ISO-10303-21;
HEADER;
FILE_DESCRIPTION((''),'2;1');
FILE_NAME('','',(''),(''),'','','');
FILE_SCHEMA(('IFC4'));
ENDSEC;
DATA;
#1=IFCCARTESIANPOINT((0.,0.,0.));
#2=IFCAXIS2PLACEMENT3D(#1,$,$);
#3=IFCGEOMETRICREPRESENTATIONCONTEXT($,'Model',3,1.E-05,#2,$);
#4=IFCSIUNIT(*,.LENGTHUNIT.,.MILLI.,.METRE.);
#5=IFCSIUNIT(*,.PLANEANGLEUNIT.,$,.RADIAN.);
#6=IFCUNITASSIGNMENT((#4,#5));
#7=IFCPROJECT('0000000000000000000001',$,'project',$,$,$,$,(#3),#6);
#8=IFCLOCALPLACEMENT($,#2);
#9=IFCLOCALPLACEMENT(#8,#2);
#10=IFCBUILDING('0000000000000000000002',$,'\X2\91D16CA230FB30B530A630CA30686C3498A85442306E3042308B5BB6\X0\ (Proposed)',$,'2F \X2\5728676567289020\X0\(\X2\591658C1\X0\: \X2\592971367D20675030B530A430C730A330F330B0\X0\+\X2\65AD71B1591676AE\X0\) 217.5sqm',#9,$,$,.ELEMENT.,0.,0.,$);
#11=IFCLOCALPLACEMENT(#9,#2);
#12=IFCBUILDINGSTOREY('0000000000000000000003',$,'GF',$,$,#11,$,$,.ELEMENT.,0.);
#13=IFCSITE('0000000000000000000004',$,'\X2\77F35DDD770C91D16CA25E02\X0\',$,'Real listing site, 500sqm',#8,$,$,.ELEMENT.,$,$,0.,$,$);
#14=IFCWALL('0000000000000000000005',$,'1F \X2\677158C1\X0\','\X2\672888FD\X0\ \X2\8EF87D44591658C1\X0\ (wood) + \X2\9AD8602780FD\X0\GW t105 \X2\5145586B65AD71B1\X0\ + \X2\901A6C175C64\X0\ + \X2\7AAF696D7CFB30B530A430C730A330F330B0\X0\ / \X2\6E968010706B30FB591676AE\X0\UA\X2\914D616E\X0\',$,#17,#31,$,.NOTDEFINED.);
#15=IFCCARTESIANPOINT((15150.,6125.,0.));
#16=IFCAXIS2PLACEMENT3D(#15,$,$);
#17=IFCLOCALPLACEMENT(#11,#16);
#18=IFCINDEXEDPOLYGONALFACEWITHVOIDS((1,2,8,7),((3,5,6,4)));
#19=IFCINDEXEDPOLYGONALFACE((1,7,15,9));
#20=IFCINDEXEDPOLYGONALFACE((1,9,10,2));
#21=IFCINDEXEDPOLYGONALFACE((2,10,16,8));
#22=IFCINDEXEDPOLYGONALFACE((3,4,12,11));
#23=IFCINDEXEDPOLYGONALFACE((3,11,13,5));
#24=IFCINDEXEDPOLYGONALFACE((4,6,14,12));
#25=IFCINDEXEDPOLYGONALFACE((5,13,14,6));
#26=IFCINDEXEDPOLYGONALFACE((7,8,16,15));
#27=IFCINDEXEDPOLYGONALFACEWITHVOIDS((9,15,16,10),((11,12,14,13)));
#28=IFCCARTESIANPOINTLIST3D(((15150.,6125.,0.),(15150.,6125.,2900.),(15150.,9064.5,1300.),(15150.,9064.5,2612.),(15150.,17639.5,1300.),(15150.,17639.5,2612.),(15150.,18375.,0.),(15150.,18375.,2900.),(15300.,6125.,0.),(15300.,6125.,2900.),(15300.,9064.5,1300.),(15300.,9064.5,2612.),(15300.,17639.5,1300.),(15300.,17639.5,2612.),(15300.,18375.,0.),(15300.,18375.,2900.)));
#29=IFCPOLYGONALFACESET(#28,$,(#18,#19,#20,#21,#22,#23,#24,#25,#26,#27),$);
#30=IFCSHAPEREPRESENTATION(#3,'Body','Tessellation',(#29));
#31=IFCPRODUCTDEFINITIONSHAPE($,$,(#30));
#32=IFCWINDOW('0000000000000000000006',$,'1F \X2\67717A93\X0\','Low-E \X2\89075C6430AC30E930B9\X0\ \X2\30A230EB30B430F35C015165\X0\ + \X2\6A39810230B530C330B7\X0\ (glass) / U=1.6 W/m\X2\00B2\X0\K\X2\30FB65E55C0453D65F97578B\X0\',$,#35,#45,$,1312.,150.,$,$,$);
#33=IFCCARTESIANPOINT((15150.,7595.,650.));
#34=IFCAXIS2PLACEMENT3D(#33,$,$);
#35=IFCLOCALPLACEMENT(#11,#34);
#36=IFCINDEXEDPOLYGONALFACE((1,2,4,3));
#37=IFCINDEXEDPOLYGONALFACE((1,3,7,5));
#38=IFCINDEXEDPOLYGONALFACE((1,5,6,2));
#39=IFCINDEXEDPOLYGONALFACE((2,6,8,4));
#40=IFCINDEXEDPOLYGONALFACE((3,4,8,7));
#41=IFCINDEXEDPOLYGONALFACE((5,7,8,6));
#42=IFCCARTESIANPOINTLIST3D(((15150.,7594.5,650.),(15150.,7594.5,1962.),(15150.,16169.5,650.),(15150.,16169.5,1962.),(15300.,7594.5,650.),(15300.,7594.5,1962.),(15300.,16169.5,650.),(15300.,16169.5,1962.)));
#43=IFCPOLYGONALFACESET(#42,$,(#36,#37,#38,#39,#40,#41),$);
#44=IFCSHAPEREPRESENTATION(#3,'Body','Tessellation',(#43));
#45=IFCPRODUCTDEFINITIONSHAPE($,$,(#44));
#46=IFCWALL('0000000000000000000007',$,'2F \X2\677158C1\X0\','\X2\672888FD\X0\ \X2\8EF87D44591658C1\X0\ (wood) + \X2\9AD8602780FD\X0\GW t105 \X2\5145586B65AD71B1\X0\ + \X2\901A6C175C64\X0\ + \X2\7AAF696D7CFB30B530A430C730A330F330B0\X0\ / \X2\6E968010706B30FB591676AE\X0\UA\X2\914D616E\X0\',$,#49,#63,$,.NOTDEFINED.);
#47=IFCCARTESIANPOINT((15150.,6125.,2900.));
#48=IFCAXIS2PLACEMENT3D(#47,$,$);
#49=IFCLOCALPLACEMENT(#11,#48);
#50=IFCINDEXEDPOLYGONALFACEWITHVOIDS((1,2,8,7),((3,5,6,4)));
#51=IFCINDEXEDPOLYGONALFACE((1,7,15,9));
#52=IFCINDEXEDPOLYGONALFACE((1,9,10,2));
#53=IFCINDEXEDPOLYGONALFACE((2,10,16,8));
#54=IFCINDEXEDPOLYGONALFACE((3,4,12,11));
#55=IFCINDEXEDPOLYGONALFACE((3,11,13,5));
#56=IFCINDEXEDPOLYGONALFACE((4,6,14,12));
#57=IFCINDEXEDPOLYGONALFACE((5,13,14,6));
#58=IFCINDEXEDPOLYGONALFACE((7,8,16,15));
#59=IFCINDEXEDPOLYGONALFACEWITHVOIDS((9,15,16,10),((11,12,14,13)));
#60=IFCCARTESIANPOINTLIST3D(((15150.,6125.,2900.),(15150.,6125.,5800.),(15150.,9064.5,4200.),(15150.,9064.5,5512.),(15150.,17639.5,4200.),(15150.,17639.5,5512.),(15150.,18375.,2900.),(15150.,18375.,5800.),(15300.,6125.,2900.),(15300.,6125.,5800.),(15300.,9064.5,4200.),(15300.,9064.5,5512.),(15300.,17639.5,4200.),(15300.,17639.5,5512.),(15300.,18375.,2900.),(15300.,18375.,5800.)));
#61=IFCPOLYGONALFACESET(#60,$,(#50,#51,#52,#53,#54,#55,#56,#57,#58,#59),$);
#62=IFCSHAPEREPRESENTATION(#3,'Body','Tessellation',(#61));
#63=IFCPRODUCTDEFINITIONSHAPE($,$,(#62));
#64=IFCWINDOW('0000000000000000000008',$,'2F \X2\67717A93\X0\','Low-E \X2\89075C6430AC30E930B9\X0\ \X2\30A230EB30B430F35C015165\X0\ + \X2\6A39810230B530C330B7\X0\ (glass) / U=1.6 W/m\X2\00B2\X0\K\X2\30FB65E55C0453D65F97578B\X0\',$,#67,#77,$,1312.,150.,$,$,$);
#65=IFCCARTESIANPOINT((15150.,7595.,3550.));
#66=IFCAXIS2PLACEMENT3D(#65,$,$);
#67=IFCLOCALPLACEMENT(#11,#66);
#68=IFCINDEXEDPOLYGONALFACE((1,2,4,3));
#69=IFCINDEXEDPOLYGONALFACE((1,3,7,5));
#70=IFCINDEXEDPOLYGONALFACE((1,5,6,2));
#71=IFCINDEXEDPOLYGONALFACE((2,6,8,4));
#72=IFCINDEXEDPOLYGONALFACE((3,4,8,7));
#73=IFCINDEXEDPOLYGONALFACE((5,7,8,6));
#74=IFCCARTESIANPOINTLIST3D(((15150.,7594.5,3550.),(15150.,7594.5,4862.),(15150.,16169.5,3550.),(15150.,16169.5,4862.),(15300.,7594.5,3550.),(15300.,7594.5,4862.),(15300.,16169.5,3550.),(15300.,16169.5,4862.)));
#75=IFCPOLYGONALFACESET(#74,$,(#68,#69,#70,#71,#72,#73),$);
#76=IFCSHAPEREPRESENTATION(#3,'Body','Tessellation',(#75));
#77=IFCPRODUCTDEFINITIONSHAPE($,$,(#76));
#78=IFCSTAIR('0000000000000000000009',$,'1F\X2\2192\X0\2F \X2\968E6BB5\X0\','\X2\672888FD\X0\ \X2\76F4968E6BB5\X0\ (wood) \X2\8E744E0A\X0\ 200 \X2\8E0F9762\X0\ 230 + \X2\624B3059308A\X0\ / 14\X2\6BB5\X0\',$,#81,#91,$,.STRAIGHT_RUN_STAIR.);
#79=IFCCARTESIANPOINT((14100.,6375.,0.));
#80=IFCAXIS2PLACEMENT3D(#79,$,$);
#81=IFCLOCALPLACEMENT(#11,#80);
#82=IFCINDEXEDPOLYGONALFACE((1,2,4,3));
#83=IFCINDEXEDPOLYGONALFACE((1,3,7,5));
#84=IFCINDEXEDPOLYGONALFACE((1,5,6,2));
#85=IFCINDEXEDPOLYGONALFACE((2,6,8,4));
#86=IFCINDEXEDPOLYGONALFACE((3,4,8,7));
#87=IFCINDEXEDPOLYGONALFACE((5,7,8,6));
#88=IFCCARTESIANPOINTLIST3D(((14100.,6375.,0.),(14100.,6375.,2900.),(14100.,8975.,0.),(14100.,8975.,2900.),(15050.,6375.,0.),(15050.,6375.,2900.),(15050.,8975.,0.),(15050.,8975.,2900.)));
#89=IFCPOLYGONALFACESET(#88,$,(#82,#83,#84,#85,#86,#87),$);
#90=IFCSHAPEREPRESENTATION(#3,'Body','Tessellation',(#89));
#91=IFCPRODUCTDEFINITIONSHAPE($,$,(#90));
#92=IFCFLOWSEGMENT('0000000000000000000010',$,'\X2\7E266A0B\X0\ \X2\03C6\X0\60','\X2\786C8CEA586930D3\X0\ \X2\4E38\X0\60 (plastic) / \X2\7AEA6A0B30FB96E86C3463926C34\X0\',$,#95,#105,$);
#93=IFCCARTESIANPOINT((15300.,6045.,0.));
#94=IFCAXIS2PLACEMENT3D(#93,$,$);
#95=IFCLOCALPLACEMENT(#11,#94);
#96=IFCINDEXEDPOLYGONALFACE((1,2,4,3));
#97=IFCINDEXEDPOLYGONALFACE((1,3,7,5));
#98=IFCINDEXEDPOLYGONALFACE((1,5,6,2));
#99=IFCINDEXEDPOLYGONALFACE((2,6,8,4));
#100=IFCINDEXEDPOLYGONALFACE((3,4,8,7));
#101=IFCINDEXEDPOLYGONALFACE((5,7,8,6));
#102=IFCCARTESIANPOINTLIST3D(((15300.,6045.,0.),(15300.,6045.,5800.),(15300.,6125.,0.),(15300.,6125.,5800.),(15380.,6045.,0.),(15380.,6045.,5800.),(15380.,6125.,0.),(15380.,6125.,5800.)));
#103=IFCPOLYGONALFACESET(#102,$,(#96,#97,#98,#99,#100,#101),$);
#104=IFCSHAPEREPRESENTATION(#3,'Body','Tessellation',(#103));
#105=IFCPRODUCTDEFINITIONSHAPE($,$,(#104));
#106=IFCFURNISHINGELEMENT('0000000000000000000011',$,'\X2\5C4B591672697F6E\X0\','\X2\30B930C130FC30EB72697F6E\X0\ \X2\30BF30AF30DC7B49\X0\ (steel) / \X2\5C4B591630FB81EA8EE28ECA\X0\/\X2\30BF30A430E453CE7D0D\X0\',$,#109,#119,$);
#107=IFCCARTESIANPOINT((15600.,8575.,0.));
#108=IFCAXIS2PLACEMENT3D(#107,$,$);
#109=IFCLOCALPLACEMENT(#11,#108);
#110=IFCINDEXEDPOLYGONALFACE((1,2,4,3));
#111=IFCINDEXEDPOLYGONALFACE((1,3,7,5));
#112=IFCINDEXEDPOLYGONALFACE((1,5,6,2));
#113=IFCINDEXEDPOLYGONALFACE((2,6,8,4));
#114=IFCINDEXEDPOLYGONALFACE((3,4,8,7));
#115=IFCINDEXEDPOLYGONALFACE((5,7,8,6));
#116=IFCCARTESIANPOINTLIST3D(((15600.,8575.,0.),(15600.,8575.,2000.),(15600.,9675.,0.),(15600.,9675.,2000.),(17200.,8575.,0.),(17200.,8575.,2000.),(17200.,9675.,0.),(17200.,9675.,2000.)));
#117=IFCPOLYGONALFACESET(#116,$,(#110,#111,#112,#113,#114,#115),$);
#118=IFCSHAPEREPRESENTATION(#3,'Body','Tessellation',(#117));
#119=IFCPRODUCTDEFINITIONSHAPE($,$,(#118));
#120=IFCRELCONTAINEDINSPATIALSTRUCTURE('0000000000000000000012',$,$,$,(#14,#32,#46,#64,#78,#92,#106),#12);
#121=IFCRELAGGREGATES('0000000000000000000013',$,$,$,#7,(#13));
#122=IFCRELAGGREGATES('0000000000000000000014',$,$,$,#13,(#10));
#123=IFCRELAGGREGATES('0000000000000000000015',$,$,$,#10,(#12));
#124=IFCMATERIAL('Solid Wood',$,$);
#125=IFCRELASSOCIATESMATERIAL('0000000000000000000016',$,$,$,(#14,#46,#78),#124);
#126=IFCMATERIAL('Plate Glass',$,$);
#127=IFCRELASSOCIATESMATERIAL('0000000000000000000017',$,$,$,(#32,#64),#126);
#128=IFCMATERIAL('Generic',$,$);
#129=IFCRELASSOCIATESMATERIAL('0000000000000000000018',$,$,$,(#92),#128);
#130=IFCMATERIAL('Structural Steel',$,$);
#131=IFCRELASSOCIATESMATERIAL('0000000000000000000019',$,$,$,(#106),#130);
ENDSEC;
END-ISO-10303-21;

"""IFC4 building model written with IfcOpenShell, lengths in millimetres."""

from ifc_helpers import new_model, si_unit, frame, frame_2d, origin, place, context, project, spatial, rectangle, extrude, material, element, fill, save


model = new_model("IFC4")

# Units and contexts
model_context = context("Model", 3, precision=1e-05, world=origin())
ifc_project = project(units=[si_unit("LENGTHUNIT", "METRE", prefix="MILLI"), si_unit("PLANEANGLEUNIT", "RADIAN")], contexts=[model_context])

# Site, building, storey
site_placement = place(None, origin())
site = spatial("IfcSite", under=ifc_project, at=site_placement, Name="石川県金沢市", ObjectType="Real listing site, 500sqm", CompositionType="ELEMENT", RefElevation=0.0)
building_placement = place(site_placement, origin())
building = spatial("IfcBuilding", under=site, at=building_placement, Name="金沢・サウナと水風呂のある家 (Proposed)", ObjectType="2F 在来木造(外壁: 天然素材サイディング+断熱外皮) 217.5sqm", CompositionType="ELEMENT", ElevationOfRefHeight=0.0, ElevationOfTerrain=0.0)
storey_placement = place(building_placement, origin())
storey = spatial("IfcBuildingStorey", under=building, at=storey_placement, Name="GF", CompositionType="ELEMENT", Elevation=0.0)

# Shared definitions
ifc_material_1 = material(Name="Solid Wood")

# Walls, openings, windows
wall_1_placement = place(storey_placement, frame((15150.0, 6125.0, 0.0)))
wall_1 = element("IfcWall", 1, at=wall_1_placement, inside=storey, material=ifc_material_1, Name="1F 東壁", Description="木製 軸組外壁 (wood) + 高性能GW t105 充填断熱 + 通気層 + 窯業系サイディング / 準耐火・外皮UA配慮", PredefinedType="NOTDEFINED", context=model_context, shape_type="SweptSolid", body=[
    extrude(rectangle(XDim=150.0, YDim=12250.0, at=frame_2d((75.0, 6125.0))), frame((15150.0, 6125.0, 0.0)), (0.0, 0.0, 1.0), 2900.0),
])
opening_1_placement = place(storey_placement, frame((15150.0, 7595.0, 650.0)))
opening_1 = element("IfcOpeningElement", 2, at=opening_1_placement, cuts=wall_1, PredefinedType="NOTDEFINED", context=model_context, shape_type="SweptSolid", body=[
    extrude(rectangle(XDim=150.0, YDim=8575.0, at=frame_2d((75.0, 4287.0))), frame((15150.0, 7595.0, 650.0)), (0.0, 0.0, 1.0), 1312.0),
])
ifc_material_2 = material(Name="Plate Glass")
window_1_placement = place(storey_placement, frame((15150.0, 7595.0, 650.0)))
window_1 = element("IfcWindow", 3, at=window_1_placement, inside=storey, material=ifc_material_2, Name="1F 東窓", Description="Low-E 複層ガラス アルゴン封入 + 樹脂サッシ (glass) / U=1.6 W/m²K・日射取得型", OverallHeight=1312.0, OverallWidth=150.0, context=model_context, shape_type="SweptSolid", body=[
    extrude(rectangle(XDim=150.0, YDim=8575.0, at=frame_2d((75.0, 4287.0))), frame((15150.0, 7595.0, 650.0)), (0.0, 0.0, 1.0), 1312.0),
])
fill(opening_1, window_1)
wall_2_placement = place(storey_placement, frame((15150.0, 6125.0, 2900.0)))
wall_2 = element("IfcWall", 4, at=wall_2_placement, inside=storey, material=ifc_material_1, Name="2F 東壁", Description="木製 軸組外壁 (wood) + 高性能GW t105 充填断熱 + 通気層 + 窯業系サイディング / 準耐火・外皮UA配慮", PredefinedType="NOTDEFINED", context=model_context, shape_type="SweptSolid", body=[
    extrude(rectangle(XDim=150.0, YDim=12250.0, at=frame_2d((75.0, 6125.0))), frame((15150.0, 6125.0, 2900.0)), (0.0, 0.0, 1.0), 2900.0),
])
opening_2_placement = place(storey_placement, frame((15150.0, 7595.0, 3550.0)))
opening_2 = element("IfcOpeningElement", 5, at=opening_2_placement, cuts=wall_2, PredefinedType="NOTDEFINED", context=model_context, shape_type="SweptSolid", body=[
    extrude(rectangle(XDim=150.0, YDim=8575.0, at=frame_2d((75.0, 4287.0))), frame((15150.0, 7595.0, 3550.0)), (0.0, 0.0, 1.0), 1312.0),
])
window_2_placement = place(storey_placement, frame((15150.0, 7595.0, 3550.0)))
window_2 = element("IfcWindow", 6, at=window_2_placement, inside=storey, material=ifc_material_2, Name="2F 東窓", Description="Low-E 複層ガラス アルゴン封入 + 樹脂サッシ (glass) / U=1.6 W/m²K・日射取得型", OverallHeight=1312.0, OverallWidth=150.0, context=model_context, shape_type="SweptSolid", body=[
    extrude(rectangle(XDim=150.0, YDim=8575.0, at=frame_2d((75.0, 4287.0))), frame((15150.0, 7595.0, 3550.0)), (0.0, 0.0, 1.0), 1312.0),
])
fill(opening_2, window_2)

# Stair
stair_placement = place(storey_placement, frame((14100.0, 6375.0, 0.0)))
element("IfcStair", 7, at=stair_placement, inside=storey, material=ifc_material_1, Name="1F→2F 階段", Description="木製 直階段 (wood) 蹴上 200 踏面 230 + 手すり / 14段", PredefinedType="STRAIGHT_RUN_STAIR", context=model_context, shape_type="SweptSolid", body=[
    extrude(rectangle(XDim=950.0, YDim=2600.0, at=frame_2d((475.0, 1300.0))), frame((14100.0, 6375.0, 0.0)), (0.0, 0.0, 1.0), 2900.0),
])

# Flow segment
ifc_material_3 = material(Name="Generic")
flow_segment_placement = place(storey_placement, frame((15300.0, 6045.0, 0.0)))
element("IfcFlowSegment", 8, at=flow_segment_placement, inside=storey, material=ifc_material_3, Name="縦樋 φ60", Description="硬質塩ビ 丸60 (plastic) / 竪樋・雨水排水", context=model_context, shape_type="SweptSolid", body=[
    extrude(rectangle(XDim=80.0, YDim=80.0, at=frame_2d((40.0, 40.0))), frame((15300.0, 6045.0, 0.0)), (0.0, 0.0, 1.0), 5800.0),
])

# Furnishing element
ifc_material_4 = material(Name="Structural Steel")
furnishing_placement = place(storey_placement, frame((15600.0, 8575.0, 0.0)))
element("IfcFurnishingElement", 9, at=furnishing_placement, inside=storey, material=ifc_material_4, Name="屋外物置", Description="スチール物置 タクボ等 (steel) / 屋外・自転車/タイヤ収納", context=model_context, shape_type="SweptSolid", body=[
    extrude(rectangle(XDim=1600.0, YDim=1100.0, at=frame_2d((800.0, 550.0))), frame((15600.0, 8575.0, 0.0)), (0.0, 0.0, 1.0), 2000.0),
])

save(model, "model.ifc")
